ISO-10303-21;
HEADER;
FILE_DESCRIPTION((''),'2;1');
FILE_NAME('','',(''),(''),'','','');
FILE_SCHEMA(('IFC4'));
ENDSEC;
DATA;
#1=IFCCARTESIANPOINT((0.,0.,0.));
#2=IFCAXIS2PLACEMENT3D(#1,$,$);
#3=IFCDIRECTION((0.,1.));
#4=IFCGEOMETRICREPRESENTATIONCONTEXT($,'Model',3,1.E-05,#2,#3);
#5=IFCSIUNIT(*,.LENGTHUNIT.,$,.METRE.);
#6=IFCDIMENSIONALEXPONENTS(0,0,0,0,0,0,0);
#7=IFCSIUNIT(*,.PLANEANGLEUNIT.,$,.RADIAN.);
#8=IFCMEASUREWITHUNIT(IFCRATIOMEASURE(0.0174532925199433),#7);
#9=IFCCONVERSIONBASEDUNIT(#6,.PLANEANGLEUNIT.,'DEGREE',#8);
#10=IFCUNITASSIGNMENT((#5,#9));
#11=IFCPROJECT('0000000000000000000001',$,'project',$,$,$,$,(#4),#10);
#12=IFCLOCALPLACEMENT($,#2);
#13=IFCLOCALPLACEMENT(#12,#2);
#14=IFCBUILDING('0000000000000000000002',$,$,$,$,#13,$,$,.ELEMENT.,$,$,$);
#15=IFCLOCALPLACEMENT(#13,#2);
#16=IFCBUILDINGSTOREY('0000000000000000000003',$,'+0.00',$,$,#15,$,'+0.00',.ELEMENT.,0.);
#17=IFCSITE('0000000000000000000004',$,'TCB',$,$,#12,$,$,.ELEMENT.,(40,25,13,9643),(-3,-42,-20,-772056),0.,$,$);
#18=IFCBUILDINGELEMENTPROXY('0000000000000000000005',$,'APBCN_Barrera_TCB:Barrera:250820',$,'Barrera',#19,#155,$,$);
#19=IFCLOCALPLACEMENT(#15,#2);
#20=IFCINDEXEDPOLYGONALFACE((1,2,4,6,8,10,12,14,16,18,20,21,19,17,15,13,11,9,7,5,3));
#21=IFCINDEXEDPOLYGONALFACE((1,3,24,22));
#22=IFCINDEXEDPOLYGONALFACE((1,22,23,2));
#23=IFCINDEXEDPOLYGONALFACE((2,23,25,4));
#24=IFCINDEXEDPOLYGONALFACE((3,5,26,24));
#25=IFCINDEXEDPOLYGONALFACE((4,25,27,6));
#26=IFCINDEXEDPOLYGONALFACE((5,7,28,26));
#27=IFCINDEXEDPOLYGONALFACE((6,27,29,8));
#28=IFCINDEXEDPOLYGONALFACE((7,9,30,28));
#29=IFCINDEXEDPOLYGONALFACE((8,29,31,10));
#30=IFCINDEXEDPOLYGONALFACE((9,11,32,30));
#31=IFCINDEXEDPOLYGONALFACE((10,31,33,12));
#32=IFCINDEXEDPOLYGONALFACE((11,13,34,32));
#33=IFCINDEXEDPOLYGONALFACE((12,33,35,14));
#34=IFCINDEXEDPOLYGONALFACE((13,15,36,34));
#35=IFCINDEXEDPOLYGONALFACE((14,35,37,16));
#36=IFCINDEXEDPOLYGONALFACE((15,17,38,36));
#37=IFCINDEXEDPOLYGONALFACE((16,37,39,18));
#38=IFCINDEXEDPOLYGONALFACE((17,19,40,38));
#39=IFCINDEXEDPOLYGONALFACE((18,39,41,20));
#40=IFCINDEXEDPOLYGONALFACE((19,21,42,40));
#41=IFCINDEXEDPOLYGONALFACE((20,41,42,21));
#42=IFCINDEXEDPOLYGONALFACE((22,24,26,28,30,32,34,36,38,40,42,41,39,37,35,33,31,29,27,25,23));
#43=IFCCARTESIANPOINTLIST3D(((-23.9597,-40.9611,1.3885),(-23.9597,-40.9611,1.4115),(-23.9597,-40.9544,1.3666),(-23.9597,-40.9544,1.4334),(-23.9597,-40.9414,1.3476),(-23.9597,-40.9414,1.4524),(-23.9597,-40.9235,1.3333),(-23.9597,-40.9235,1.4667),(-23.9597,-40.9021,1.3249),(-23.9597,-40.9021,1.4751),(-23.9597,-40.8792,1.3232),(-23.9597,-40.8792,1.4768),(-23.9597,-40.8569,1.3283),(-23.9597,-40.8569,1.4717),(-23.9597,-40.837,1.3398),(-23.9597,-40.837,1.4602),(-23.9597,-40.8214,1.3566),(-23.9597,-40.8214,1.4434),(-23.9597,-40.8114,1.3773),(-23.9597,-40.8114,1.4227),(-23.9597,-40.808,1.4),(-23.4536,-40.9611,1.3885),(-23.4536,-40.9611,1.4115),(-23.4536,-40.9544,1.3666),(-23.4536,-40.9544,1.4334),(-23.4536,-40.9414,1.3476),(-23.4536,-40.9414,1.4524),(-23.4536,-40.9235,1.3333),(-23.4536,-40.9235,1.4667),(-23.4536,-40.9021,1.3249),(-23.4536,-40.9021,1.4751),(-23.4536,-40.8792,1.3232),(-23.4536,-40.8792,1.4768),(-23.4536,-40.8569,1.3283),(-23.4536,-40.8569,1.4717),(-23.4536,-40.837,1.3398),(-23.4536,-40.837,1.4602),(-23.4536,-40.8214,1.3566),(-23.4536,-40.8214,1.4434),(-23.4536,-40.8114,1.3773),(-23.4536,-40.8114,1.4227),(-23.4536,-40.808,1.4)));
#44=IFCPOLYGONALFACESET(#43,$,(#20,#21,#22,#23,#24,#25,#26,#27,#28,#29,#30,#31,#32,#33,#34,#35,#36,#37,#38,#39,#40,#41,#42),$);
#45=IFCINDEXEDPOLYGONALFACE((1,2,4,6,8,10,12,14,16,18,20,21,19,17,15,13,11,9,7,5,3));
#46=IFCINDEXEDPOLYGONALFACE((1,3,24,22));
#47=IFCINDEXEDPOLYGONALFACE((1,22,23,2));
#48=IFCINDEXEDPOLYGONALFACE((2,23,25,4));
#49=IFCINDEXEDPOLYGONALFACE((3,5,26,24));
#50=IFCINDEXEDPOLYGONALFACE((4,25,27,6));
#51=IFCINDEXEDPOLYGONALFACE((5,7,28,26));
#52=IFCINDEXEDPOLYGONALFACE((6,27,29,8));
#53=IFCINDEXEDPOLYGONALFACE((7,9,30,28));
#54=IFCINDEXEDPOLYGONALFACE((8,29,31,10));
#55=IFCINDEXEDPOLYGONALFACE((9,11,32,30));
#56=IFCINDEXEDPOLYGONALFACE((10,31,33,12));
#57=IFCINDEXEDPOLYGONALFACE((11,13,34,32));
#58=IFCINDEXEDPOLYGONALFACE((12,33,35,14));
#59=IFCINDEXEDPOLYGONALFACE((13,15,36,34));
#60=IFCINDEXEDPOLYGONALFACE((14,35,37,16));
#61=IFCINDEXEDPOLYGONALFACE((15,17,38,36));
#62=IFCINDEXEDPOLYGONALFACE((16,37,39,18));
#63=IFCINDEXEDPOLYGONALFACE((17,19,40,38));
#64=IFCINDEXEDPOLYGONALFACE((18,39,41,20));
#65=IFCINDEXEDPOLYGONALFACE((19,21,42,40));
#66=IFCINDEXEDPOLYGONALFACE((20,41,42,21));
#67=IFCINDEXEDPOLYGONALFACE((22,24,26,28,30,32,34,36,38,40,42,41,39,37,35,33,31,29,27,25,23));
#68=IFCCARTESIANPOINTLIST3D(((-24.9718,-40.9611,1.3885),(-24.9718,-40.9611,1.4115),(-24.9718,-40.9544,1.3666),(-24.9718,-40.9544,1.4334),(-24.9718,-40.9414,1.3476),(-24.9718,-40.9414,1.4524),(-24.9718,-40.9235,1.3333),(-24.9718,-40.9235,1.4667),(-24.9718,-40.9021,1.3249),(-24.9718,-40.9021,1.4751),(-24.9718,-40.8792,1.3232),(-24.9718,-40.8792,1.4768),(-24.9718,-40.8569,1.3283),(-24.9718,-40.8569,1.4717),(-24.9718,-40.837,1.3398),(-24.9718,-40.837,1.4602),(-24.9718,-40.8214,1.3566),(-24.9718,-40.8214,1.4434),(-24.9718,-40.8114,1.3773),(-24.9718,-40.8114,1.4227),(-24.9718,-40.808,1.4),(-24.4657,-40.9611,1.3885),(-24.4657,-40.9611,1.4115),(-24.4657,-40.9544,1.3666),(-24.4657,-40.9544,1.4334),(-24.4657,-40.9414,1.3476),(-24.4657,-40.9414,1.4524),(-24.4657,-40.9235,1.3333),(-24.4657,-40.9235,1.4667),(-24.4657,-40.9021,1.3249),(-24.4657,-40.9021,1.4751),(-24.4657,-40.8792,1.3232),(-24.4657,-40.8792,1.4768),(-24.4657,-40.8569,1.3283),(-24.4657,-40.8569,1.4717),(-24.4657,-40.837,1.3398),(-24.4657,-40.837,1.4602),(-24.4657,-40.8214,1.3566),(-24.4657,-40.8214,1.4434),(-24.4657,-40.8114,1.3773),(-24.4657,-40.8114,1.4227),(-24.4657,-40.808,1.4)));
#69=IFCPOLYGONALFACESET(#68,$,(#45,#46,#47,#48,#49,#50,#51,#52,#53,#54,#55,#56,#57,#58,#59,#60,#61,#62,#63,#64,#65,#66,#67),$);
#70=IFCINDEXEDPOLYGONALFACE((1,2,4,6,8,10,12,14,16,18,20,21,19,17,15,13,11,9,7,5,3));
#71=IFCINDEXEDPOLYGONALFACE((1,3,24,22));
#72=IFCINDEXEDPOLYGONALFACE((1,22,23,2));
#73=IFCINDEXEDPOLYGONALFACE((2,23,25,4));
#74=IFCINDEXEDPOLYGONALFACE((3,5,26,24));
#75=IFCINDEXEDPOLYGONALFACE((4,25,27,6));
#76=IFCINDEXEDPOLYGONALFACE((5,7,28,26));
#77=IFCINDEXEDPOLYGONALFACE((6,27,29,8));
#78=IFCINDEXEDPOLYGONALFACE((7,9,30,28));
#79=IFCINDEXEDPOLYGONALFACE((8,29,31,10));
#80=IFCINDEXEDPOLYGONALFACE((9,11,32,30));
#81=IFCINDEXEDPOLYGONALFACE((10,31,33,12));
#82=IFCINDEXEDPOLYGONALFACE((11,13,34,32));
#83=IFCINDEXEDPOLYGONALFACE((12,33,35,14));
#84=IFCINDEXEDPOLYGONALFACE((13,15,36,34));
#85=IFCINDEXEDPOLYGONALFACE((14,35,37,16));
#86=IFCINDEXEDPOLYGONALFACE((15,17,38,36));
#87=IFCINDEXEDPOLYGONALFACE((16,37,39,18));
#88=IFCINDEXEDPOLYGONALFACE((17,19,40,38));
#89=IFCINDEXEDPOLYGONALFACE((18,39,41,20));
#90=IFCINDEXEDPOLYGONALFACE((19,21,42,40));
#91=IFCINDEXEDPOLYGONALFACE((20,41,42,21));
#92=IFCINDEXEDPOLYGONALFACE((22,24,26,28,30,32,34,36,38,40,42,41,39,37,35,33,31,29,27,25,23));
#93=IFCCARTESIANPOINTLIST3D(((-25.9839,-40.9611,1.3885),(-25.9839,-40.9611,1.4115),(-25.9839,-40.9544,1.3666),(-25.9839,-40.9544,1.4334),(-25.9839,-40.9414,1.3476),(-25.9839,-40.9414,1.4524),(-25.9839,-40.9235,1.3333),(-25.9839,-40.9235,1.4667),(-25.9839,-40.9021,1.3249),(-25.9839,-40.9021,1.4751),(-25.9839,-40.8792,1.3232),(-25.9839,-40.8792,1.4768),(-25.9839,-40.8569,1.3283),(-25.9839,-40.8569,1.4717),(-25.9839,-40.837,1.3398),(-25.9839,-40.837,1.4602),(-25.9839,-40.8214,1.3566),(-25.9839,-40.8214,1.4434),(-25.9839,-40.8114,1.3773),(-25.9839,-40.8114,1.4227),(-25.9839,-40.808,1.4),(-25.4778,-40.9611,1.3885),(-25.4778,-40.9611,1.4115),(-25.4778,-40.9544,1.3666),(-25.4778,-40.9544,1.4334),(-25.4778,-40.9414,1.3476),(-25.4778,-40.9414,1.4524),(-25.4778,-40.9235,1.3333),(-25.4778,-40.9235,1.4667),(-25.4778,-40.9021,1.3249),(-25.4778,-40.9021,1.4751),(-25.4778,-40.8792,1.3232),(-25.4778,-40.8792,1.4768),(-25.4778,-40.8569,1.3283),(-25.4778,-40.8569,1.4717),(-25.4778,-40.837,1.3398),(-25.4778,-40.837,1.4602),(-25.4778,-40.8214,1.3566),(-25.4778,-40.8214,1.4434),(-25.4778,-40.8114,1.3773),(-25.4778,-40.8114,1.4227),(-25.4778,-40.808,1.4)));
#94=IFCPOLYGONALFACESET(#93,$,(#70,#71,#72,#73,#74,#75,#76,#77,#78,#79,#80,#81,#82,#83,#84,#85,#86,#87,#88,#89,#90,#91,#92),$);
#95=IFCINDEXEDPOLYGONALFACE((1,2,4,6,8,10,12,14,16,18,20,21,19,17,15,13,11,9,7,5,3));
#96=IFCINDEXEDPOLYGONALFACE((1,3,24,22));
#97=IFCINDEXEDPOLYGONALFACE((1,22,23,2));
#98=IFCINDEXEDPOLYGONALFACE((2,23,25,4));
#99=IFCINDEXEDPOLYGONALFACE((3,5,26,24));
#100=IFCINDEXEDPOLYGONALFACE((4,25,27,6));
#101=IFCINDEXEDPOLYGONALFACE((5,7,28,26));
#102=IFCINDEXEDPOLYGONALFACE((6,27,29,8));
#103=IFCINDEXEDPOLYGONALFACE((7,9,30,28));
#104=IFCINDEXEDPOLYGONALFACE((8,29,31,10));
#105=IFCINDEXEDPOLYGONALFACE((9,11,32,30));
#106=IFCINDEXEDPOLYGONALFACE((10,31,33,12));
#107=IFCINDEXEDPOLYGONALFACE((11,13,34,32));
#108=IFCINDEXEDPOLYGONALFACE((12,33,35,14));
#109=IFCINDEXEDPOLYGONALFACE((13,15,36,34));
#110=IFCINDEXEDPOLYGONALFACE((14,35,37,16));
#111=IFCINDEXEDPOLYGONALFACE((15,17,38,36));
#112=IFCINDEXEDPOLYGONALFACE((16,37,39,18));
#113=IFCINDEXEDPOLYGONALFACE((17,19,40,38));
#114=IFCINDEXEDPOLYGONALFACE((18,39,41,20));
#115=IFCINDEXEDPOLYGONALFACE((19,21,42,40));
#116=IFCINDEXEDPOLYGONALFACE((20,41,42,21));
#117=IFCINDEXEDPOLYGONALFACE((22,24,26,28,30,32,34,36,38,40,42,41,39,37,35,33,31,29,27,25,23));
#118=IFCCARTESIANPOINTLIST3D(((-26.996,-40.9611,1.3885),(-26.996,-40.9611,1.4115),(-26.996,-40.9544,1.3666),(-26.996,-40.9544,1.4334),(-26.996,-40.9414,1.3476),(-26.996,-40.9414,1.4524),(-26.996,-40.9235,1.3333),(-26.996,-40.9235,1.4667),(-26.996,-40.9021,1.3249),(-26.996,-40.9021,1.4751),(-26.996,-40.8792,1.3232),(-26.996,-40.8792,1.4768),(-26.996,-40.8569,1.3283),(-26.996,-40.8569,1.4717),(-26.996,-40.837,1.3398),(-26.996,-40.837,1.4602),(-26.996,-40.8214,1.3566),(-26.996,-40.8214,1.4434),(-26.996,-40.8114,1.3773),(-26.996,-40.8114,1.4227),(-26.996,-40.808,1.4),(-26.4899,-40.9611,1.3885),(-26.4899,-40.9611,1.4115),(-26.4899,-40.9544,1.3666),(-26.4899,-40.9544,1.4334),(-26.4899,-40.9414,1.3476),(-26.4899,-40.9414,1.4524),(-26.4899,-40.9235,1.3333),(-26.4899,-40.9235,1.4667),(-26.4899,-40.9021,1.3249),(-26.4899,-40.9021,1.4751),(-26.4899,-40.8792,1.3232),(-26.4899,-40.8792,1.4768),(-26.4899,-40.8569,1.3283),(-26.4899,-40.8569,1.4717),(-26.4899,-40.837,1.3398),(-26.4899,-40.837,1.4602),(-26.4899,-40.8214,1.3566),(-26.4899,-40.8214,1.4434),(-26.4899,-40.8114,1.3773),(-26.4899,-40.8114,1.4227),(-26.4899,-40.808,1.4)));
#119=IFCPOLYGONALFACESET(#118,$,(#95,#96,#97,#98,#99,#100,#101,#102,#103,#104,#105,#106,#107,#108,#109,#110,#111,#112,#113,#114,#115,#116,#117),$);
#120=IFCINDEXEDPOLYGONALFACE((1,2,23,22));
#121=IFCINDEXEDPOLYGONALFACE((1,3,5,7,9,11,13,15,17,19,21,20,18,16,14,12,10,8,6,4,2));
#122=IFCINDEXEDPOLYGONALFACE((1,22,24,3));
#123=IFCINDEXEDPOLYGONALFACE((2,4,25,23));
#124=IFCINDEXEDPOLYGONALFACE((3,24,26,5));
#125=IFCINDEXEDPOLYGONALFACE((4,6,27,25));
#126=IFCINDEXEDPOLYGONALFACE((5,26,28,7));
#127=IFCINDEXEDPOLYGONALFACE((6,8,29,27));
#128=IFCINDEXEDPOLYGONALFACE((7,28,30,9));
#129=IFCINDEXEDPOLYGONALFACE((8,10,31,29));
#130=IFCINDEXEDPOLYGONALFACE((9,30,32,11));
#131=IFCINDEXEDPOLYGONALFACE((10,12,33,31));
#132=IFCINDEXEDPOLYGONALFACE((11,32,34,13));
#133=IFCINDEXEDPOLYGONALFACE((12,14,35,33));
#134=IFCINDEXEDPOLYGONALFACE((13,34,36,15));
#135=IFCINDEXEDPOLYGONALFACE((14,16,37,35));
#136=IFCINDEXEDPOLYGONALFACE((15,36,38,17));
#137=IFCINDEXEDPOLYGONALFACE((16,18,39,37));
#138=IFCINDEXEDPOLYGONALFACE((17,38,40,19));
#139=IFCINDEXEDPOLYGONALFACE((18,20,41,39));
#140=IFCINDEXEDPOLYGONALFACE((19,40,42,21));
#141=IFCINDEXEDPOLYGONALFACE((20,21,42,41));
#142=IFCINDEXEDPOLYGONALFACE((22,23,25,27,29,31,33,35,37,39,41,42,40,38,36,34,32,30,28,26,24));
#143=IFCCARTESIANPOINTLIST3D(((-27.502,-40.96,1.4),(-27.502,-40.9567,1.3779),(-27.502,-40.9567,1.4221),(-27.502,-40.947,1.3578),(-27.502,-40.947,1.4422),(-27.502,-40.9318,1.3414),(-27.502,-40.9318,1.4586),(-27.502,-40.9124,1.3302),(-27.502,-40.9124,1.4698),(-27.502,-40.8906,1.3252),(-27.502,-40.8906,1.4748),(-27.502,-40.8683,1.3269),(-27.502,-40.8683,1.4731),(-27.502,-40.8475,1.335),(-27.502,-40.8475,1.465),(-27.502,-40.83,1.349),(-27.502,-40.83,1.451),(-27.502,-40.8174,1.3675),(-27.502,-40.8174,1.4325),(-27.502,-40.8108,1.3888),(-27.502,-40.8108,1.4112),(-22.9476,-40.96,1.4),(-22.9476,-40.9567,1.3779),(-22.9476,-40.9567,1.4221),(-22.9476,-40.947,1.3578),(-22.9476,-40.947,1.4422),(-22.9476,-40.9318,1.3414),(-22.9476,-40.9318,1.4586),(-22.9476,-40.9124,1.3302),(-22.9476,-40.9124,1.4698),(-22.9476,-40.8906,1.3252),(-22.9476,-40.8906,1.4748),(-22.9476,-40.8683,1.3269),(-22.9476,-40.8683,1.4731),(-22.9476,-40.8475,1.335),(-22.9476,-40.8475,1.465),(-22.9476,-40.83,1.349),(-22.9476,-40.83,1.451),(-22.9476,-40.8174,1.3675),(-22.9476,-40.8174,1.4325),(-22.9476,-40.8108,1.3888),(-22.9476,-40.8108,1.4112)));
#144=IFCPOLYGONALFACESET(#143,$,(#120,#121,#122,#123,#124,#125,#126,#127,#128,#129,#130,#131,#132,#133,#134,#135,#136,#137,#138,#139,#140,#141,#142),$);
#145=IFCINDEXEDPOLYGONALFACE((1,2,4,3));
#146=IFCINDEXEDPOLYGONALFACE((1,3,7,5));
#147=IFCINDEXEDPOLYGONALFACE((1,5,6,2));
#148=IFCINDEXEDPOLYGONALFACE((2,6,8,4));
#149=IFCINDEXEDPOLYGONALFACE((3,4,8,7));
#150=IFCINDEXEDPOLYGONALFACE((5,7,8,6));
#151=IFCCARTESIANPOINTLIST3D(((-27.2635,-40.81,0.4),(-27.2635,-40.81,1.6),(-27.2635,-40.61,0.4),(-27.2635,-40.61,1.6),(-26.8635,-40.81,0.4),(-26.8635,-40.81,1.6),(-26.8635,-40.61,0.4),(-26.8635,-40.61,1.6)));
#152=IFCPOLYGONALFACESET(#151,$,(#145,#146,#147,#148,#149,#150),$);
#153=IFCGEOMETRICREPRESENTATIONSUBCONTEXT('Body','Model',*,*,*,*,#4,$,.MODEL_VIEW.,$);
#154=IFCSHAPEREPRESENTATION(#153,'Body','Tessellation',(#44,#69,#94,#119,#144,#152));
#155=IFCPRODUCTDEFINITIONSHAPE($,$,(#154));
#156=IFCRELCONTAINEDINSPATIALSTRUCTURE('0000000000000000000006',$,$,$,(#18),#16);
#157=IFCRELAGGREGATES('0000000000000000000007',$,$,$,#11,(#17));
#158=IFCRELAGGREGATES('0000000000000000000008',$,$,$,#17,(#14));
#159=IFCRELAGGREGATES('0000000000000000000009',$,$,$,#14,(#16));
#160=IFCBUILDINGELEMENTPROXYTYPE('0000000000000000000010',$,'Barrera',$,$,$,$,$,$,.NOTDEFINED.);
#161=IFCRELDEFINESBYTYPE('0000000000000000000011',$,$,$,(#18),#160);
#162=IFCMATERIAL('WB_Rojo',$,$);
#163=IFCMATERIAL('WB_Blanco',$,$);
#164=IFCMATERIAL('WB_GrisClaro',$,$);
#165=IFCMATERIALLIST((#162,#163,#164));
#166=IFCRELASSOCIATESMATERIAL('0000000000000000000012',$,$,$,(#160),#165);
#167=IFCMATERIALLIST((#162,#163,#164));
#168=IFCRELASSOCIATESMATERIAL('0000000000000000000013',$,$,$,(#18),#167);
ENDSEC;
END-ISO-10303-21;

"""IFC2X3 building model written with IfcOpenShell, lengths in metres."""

from ifc_helpers import new_model, entity, si_unit, converted_unit, direction, frame, frame_2d, origin, place, context, subcontext, project, spatial, rectangle, circle, extrude, source, transform, mapped, material, material_list, type_object, type_shapes, element, save


model = new_model("IFC2X3")

# Units and contexts
model_context = context("Model", 3, precision=1e-05, world=origin(), true_north=direction((0.0, 1.0)))
body_context = subcontext(model_context, "Body", "Model", "MODEL_VIEW")
ifc_project = project(units=[si_unit("LENGTHUNIT", "METRE"), converted_unit("PLANEANGLEUNIT", "DEGREE", entity("IfcRatioMeasure", 0.0174532925199433), si_unit("PLANEANGLEUNIT", "RADIAN"), dimensions=[0, 0, 0, 0, 0, 0, 0])], contexts=[model_context])

# Site, building, storey
site_placement = place(None, origin())
site = spatial("IfcSite", under=ifc_project, at=site_placement, Name="TCB", CompositionType="ELEMENT", RefLatitude=(40, 25, 13, 9643), RefLongitude=(-3, -42, -20, -772056), RefElevation=0.0)
building_placement = place(site_placement, origin())
building = spatial("IfcBuilding", under=site, at=building_placement, CompositionType="ELEMENT")
storey_placement = place(building_placement, origin())
storey = spatial("IfcBuildingStorey", under=building, at=storey_placement, Name="+0.00", LongName="+0.00", CompositionType="ELEMENT", Elevation=0.0)

# Shared definitions
ifc_material_1 = material(Name="WB_GrisClaro")

# Building element proxy
ifc_material_2 = material(Name="WB_Rojo")
ifc_material_3 = material(Name="WB_Blanco")
ifc_material_list_1 = material_list([ifc_material_2, ifc_material_3, ifc_material_1])
ifc_material_list_2 = material_list([ifc_material_2, ifc_material_3, ifc_material_1])
building_element_proxy_type_1 = type_object("IfcBuildingElementProxyType", Name="Barrera", PredefinedType="NOTDEFINED", material=ifc_material_list_2)
shared_shape_1 = source(origin(), body_context, "Body", "SweptSolid", [
    extrude(circle(Radius=0.077, at=frame_2d((0.0, 0.0), x_axis=(1.0, 0.0))), frame((2.8039, -0.175, 1.0), z_axis=(1.0, 0.0, 0.0), x_axis=(0.0, 1.0, 0.0)), (0.0, 0.0, 1.0), 0.506),
    extrude(circle(Radius=0.077, at=frame_2d((0.0, 0.0), x_axis=(1.0, 0.0))), frame((1.7918, -0.175, 1.0), z_axis=(1.0, 0.0, 0.0), x_axis=(0.0, 1.0, 0.0)), (0.0, 0.0, 1.0), 0.506),
    extrude(circle(Radius=0.077, at=frame_2d((0.0, 0.0), x_axis=(1.0, 0.0))), frame((0.7797, -0.175, 1.0), z_axis=(1.0, 0.0, 0.0), x_axis=(0.0, 1.0, 0.0)), (0.0, 0.0, 1.0), 0.506),
    extrude(circle(Radius=0.077, at=frame_2d((0.0, 0.0), x_axis=(1.0, 0.0))), frame((-0.2324, -0.175, 1.0), z_axis=(1.0, 0.0, 0.0), x_axis=(0.0, 1.0, 0.0)), (0.0, 0.0, 1.0), 0.506),
    extrude(circle(Radius=0.075, at=frame_2d((0.0, 0.0), x_axis=(1.0, 0.0))), frame((-0.7385, -0.175, 1.0), z_axis=(1.0, 0.0, 0.0), x_axis=(0.0, -1.0, 0.0)), (0.0, 0.0, 1.0), 4.5544),
    extrude(rectangle(XDim=0.2, YDim=0.4, at=frame_2d((0.0, 0.0), x_axis=(1.0, 0.0))), frame((-0.3, 0.0, 0.0), z_axis=(0.0, 0.0, 1.0), x_axis=(0.0, -1.0, 0.0)), (0.0, 0.0, 1.0), 1.2),
])
type_shapes(building_element_proxy_type_1, [shared_shape_1])
proxy_1_placement = place(storey_placement, frame((-26.7635, -40.71, 0.4)))
element("IfcBuildingElementProxy", 1, at=proxy_1_placement, inside=storey, type_object=building_element_proxy_type_1, material=ifc_material_list_1, Name="APBCN_Barrera_TCB:Barrera:250820", ObjectType="Barrera", context=body_context, shape_type="MappedRepresentation", body=[
    mapped(shared_shape_1, transform((0.0, 0.0, 0.0), scale=1.0)),
])

save(model, "model.ifc")
